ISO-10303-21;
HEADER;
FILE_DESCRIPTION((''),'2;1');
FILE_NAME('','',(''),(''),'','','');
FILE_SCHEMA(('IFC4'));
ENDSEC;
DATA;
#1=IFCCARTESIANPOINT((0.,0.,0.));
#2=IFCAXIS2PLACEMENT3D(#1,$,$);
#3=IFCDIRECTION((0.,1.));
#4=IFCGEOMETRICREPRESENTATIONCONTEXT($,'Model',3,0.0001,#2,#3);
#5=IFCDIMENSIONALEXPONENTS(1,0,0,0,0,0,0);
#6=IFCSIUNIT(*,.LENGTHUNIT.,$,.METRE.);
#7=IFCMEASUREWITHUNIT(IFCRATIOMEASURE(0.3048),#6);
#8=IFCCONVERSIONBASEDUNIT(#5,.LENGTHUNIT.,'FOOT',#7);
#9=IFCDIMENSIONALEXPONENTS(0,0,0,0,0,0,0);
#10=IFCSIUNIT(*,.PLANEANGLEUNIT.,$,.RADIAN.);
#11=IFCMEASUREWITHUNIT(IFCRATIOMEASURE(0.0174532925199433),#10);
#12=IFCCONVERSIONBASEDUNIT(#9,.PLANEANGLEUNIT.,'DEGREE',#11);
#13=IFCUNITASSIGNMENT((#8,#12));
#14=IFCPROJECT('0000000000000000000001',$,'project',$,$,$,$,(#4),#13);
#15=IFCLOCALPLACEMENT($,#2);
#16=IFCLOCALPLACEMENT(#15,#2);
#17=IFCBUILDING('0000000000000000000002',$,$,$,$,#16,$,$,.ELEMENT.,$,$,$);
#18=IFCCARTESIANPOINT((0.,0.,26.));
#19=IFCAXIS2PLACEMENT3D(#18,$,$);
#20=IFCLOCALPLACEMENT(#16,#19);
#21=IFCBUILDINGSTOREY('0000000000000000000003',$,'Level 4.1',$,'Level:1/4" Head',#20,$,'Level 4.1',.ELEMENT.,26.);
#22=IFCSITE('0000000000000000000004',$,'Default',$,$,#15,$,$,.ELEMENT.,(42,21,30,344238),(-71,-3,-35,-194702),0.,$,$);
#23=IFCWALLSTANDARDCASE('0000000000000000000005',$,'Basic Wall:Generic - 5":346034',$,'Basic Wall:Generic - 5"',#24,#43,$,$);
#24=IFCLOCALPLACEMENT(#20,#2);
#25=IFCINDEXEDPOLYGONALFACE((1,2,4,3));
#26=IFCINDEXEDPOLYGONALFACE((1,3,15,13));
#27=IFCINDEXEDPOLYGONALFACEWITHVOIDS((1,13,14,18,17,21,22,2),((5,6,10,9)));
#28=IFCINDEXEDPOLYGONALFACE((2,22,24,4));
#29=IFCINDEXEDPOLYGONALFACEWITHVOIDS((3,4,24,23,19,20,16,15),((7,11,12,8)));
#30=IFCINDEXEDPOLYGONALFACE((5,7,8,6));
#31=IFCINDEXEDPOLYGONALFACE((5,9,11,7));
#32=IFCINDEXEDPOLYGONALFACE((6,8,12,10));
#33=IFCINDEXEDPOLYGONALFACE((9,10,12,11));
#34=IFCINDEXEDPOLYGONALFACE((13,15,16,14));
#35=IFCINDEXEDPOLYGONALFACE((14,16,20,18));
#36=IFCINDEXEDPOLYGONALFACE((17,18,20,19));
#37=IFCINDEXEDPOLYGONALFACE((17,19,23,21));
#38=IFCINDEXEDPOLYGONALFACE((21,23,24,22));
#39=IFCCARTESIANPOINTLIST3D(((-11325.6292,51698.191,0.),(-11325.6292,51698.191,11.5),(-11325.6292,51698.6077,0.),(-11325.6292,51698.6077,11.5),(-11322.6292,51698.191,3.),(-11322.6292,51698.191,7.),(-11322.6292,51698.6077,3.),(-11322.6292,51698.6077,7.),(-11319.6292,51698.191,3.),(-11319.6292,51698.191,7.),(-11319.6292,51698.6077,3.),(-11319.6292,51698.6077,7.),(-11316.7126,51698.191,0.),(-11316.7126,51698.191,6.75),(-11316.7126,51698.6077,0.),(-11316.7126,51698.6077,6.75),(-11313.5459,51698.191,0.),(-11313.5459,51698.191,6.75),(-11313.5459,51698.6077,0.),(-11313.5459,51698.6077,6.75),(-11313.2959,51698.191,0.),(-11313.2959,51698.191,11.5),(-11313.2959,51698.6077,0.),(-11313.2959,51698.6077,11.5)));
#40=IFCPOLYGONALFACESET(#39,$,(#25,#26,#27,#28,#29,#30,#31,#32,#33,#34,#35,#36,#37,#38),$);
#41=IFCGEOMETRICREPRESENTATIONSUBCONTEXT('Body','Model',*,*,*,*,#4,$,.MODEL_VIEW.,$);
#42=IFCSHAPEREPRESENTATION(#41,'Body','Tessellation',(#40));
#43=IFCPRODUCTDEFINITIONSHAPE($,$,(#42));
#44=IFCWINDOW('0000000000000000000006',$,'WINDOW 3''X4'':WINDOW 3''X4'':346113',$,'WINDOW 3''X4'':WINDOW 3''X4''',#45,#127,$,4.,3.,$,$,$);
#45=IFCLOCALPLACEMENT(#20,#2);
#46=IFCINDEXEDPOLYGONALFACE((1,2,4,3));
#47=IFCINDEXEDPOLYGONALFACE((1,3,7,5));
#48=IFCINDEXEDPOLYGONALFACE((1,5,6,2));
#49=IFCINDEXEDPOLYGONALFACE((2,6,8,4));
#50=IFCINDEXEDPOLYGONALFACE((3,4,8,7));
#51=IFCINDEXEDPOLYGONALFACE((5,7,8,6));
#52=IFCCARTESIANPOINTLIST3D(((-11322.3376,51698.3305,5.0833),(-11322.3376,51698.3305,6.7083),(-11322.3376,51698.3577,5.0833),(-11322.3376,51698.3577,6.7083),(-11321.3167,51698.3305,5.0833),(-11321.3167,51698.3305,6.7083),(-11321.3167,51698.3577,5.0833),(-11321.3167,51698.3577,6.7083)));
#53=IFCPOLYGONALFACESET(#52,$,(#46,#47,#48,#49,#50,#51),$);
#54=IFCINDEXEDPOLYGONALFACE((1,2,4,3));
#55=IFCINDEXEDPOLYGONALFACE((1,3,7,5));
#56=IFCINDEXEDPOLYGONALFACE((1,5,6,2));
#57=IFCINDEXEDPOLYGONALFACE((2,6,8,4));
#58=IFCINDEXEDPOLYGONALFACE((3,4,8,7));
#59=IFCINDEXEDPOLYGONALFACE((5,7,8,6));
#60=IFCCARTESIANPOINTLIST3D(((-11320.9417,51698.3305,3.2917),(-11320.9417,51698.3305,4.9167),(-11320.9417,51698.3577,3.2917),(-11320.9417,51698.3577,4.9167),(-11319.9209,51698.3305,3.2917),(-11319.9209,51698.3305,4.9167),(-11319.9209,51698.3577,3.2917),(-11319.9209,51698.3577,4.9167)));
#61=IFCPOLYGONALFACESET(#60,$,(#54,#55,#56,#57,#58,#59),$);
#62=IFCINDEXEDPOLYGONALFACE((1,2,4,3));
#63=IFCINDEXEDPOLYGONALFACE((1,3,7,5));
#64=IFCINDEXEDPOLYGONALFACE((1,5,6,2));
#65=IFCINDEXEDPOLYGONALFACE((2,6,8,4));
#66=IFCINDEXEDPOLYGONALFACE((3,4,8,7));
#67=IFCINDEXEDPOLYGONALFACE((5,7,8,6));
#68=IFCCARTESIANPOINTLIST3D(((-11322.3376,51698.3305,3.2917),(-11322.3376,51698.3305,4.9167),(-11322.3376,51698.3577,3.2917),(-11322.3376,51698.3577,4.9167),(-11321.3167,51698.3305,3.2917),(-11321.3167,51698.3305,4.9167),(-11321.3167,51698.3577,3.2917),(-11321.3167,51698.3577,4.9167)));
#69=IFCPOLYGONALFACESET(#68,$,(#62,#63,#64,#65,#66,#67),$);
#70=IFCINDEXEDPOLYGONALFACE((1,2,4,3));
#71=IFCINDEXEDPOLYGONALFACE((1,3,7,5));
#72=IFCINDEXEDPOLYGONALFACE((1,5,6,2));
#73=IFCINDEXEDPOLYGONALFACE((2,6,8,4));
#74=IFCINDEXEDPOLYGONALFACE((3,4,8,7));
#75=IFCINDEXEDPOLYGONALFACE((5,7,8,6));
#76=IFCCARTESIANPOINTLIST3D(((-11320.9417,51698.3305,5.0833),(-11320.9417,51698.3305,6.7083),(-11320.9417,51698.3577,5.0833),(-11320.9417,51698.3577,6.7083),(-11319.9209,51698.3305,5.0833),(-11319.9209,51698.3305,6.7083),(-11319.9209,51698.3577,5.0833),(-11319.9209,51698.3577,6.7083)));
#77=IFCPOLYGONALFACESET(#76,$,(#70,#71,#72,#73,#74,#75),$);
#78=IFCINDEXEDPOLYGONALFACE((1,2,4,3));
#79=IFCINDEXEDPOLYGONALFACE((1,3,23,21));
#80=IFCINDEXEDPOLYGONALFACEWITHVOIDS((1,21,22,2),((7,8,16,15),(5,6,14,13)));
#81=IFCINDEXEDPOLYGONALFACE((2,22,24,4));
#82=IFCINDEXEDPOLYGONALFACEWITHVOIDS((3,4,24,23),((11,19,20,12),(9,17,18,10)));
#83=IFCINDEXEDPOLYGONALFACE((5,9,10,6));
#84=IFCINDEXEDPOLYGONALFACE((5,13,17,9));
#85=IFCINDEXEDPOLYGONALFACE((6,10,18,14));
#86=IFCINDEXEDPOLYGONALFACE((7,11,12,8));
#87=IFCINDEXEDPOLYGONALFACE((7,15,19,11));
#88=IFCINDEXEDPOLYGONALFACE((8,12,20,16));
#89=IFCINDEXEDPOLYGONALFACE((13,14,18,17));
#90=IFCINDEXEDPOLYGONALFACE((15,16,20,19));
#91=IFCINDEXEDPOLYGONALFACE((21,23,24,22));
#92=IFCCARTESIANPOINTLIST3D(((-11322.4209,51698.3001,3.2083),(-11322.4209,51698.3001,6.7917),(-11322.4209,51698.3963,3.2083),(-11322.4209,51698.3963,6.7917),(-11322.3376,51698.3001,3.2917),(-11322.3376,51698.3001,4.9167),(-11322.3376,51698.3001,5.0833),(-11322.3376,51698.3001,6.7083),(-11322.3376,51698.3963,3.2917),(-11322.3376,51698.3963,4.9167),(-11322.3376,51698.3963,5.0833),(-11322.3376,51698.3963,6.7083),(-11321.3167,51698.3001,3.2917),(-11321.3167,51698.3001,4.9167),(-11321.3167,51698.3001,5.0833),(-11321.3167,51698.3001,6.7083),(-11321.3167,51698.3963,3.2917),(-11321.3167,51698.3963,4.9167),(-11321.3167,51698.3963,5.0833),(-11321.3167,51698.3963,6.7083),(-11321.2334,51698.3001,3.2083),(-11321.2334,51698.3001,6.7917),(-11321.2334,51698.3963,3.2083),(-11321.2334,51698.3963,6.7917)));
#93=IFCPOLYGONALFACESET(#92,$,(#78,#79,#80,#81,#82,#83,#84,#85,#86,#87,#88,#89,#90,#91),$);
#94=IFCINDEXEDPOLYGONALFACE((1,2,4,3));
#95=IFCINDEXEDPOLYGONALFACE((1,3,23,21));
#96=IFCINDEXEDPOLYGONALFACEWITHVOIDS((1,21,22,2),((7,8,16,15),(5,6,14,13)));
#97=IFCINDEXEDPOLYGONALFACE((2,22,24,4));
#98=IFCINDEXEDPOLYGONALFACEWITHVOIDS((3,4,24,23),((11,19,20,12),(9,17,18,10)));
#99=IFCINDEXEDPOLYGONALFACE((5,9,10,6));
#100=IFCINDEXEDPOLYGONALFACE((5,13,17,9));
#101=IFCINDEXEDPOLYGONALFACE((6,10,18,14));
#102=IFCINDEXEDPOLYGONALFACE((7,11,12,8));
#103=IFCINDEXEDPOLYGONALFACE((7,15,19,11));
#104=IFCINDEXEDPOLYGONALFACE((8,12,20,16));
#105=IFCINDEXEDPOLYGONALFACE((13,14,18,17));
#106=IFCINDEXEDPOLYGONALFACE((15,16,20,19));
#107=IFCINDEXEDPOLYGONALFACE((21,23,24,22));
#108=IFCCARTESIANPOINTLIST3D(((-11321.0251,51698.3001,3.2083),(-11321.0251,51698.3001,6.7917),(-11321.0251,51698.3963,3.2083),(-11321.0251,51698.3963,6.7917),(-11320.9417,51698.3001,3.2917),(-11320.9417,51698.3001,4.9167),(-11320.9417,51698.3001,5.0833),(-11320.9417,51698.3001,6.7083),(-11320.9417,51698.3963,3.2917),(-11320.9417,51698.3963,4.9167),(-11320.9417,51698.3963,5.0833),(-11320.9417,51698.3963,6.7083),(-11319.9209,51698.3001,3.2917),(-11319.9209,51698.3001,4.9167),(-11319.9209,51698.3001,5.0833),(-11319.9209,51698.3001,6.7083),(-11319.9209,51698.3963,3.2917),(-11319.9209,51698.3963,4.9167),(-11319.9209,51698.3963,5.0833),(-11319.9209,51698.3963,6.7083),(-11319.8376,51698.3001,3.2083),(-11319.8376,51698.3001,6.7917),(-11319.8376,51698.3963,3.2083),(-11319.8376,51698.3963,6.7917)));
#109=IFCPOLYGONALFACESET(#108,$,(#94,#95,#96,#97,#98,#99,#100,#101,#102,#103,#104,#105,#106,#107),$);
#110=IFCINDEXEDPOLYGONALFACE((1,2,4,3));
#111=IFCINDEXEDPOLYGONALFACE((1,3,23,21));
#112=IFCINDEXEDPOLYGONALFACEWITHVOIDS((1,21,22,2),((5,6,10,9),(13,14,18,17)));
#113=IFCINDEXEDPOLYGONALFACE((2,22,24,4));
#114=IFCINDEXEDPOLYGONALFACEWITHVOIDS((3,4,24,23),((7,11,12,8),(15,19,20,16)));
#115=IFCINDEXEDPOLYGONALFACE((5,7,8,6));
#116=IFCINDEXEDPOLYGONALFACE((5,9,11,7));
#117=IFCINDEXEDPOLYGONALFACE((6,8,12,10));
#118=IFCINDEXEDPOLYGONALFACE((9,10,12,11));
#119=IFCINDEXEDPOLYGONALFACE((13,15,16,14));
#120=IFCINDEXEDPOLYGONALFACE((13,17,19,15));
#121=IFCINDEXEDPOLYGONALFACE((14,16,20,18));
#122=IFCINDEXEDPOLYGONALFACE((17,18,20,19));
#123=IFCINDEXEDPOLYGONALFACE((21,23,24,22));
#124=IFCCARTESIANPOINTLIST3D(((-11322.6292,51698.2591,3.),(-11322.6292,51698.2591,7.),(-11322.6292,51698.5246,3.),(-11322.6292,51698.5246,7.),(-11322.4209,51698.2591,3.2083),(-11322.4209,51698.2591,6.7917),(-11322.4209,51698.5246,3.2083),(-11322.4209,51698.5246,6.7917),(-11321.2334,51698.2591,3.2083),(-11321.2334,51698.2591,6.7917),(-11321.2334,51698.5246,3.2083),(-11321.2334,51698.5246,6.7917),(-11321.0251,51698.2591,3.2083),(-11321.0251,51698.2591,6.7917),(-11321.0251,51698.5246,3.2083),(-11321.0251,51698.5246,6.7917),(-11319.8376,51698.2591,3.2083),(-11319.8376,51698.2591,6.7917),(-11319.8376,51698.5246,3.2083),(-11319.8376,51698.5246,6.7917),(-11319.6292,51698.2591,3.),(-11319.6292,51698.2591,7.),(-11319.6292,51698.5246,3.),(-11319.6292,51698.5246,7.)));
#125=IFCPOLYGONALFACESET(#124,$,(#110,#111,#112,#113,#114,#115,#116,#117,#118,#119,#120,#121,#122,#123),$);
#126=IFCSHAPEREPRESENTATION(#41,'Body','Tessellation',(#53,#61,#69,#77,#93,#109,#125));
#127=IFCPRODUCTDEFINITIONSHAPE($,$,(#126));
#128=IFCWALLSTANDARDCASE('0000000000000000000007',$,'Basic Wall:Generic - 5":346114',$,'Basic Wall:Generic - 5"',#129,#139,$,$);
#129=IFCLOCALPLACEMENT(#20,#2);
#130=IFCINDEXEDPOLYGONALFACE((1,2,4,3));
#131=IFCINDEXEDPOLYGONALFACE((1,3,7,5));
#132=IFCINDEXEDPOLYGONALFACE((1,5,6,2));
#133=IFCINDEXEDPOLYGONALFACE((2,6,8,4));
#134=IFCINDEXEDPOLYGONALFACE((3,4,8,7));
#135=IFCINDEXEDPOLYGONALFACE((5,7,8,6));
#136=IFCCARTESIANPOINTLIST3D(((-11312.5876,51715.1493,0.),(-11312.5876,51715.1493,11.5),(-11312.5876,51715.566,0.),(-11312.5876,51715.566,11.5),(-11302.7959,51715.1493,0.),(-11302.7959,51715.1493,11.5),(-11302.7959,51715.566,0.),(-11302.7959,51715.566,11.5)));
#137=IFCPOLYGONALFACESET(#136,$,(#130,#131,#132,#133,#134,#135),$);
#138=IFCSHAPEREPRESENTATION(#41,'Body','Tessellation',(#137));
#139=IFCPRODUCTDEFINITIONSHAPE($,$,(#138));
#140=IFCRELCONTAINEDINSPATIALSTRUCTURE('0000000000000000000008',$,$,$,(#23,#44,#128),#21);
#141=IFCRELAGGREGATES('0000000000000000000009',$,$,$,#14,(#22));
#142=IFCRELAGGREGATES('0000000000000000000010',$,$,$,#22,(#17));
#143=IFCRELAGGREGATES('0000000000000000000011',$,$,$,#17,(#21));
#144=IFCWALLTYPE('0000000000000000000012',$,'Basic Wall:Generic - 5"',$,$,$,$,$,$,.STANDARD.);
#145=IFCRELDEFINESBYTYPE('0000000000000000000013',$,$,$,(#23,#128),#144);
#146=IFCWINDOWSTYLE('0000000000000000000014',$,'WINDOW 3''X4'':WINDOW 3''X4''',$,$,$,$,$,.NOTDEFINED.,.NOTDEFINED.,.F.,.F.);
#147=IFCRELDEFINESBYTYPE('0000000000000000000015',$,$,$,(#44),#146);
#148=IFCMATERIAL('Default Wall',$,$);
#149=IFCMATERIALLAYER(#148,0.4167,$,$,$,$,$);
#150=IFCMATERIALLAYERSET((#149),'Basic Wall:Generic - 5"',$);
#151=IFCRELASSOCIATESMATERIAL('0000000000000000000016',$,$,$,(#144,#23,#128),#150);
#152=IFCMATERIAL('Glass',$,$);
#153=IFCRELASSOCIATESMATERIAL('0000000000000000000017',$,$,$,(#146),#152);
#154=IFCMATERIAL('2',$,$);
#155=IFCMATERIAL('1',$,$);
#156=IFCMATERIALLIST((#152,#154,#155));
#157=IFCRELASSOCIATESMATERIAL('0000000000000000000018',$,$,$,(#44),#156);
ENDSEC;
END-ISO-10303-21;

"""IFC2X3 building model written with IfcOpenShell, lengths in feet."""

from ifc_helpers import new_model, entity, si_unit, converted_unit, direction, frame, frame_2d, origin, origin_2d_with_axis, place, context, subcontext, project, spatial, polyline, rectangle, outline, extrude, source, transform, mapped, material, material_list, layer, layer_set, layer_usage, type_object, type_shapes, element, fill, save


model = new_model("IFC2X3")

# Units and contexts
model_context = context("Model", 3, precision=0.0001, world=origin(), true_north=direction((0.0, 1.0)))
body_context = subcontext(model_context, "Body", "Model", "MODEL_VIEW")
ifc_project = project(units=[converted_unit("LENGTHUNIT", "FOOT", entity("IfcRatioMeasure", 0.3048), si_unit("LENGTHUNIT", "METRE"), dimensions=[1, 0, 0, 0, 0, 0, 0]), converted_unit("PLANEANGLEUNIT", "DEGREE", entity("IfcRatioMeasure", 0.0174532925199433), si_unit("PLANEANGLEUNIT", "RADIAN"), dimensions=[0, 0, 0, 0, 0, 0, 0])], contexts=[model_context])

# Site, building, storey
site_placement = place(None, origin())
site = spatial("IfcSite", under=ifc_project, at=site_placement, Name="Default", CompositionType="ELEMENT", RefLatitude=(42, 21, 30, 344238), RefLongitude=(-71, -3, -35, -194702), RefElevation=0.0)
building_placement = place(site_placement, origin())
building = spatial("IfcBuilding", under=site, at=building_placement, CompositionType="ELEMENT")
storey_placement = place(building_placement, frame((0.0, 0.0, 26.0)))
storey = spatial("IfcBuildingStorey", under=building, at=storey_placement, Name="Level 4.1", ObjectType="Level:1/4\" Head", LongName="Level 4.1", CompositionType="ELEMENT", Elevation=26.0)

# Shared definitions
ifc_material_1 = material(Name="Default Wall")

# Shared definitions
ifc_layer_1 = layer(ifc_material_1, 0.4167)
ifc_layer_set_1 = layer_set([ifc_layer_1], Name="Basic Wall:Generic - 5\"")
wall_type_1 = type_object("IfcWallType", Name="Basic Wall:Generic - 5\"", PredefinedType="STANDARD", material=ifc_layer_set_1)
ifc_material_2 = material(Name="Glass")
ifc_material_3 = material(Name="2")
ifc_material_4 = material(Name="1")

# Wall, openings, window
window_style_1 = type_object("IfcWindowStyle", Name="WINDOW 3'X4':WINDOW 3'X4'", ConstructionType="NOTDEFINED", OperationType="NOTDEFINED", ParameterTakesPrecedence=False, Sizeable=False, material=ifc_material_2)
shared_shape_1 = source(origin(), body_context, "Body", "SweptSolid", [
    extrude(rectangle(XDim=0.0272, YDim=1.0208, at=origin_2d_with_axis()), frame((2.1979, 0.2636, 2.0833), z_axis=(0.0, 0.0, 1.0), x_axis=(0.0, 1.0, 0.0)), (0.0, 0.0, 1.0), 1.625),
    extrude(rectangle(XDim=0.0272, YDim=1.0208, at=origin_2d_with_axis()), frame((0.8021, 0.2636, 0.2917), z_axis=(0.0, 0.0, 1.0), x_axis=(0.0, 1.0, 0.0)), (0.0, 0.0, 1.0), 1.625),
    extrude(rectangle(XDim=0.0272, YDim=1.0208, at=origin_2d_with_axis()), frame((2.1979, 0.2636, 0.2917), z_axis=(0.0, 0.0, 1.0), x_axis=(0.0, 1.0, 0.0)), (0.0, 0.0, 1.0), 1.625),
    extrude(rectangle(XDim=0.0272, YDim=1.0208, at=origin_2d_with_axis()), frame((0.8021, 0.2636, 2.0833), z_axis=(0.0, 0.0, 1.0), x_axis=(0.0, 1.0, 0.0)), (0.0, 0.0, 1.0), 1.625),
    extrude(outline(polyline([(-0.5938, -1.7917), (0.5938, -1.7917), (0.5938, 1.7917), (-0.5938, 1.7917), (-0.5938, -1.7917)]), holes=[polyline([(-0.5104, -0.0833), (0.5104, -0.0833), (0.5104, -1.7083), (-0.5104, -1.7083), (-0.5104, -0.0833)]), polyline([(-0.5104, 1.7083), (0.5104, 1.7083), (0.5104, 0.0833), (-0.5104, 0.0833), (-0.5104, 1.7083)])]), frame((2.1979, 0.2114, 2.0), z_axis=(0.0, 1.0, 0.0), x_axis=(-1.0, 0.0, 0.0)), (0.0, 0.0, 1.0), 0.0962),
    extrude(outline(polyline([(-1.7917, -0.5937), (1.7917, -0.5937), (1.7917, 0.5937), (-1.7917, 0.5937), (-1.7917, -0.5937)]), holes=[polyline([(0.0833, -0.5104), (0.0833, 0.5104), (1.7083, 0.5104), (1.7083, -0.5104), (0.0833, -0.5104)]), polyline([(-1.7083, -0.5104), (-1.7083, 0.5104), (-0.0833, 0.5104), (-0.0833, -0.5104), (-1.7083, -0.5104)])]), frame((0.8021, 0.2114, 2.0), z_axis=(0.0, 1.0, 0.0), x_axis=(0.0, 0.0, -1.0)), (0.0, 0.0, 1.0), 0.0962),
    extrude(outline(polyline([(-1.5, -2.0), (1.5, -2.0), (1.5, 2.0), (-1.5, 2.0), (-1.5, -2.0)]), holes=[polyline([(-0.1042, 1.7917), (-0.1042, -1.7917), (-1.2917, -1.7917), (-1.2917, 1.7917), (-0.1042, 1.7917)]), polyline([(0.1042, -1.7917), (0.1042, 1.7917), (1.2917, 1.7917), (1.2917, -1.7917), (0.1042, -1.7917)])]), frame((1.5, 0.0831, 2.0), z_axis=(0.0, 1.0, 0.0), x_axis=(1.0, 0.0, 0.0)), (0.0, 0.0, 1.0), 0.2655),
])
type_shapes(window_style_1, [shared_shape_1])
ifc_layer_usage_1 = layer_usage(ifc_layer_set_1, "AXIS2", "NEGATIVE", 0.2083)
wall_1_placement = place(storey_placement, frame((-11325.6292, 51698.3993, 0.0)))
wall_1 = element("IfcWallStandardCase", 1, at=wall_1_placement, inside=storey, type_object=wall_type_1, material=ifc_layer_usage_1, Name="Basic Wall:Generic - 5\":346034", ObjectType="Basic Wall:Generic - 5\"", context=body_context, shape_type="SweptSolid", body=[
    extrude(rectangle(XDim=12.3333, YDim=0.4167, at=frame_2d((6.1667, 0.0), x_axis=(-1.0, 0.0))), origin(), (0.0, 0.0, 1.0), 11.5),
])
opening_1_placement = place(wall_1_placement, frame((8.9167, -0.2083, 0.0)))
element("IfcOpeningElement", 2, at=opening_1_placement, cuts=wall_1, ObjectType="Opening", context=body_context, shape_type="SweptSolid", body=[
    extrude(rectangle(XDim=6.75, YDim=3.1667, at=frame_2d((3.375, 1.5833), x_axis=(1.0, 0.0))), frame((0.0, 0.0, 0.0), z_axis=(0.0, 1.0, 0.0), x_axis=(0.0, 0.0, 1.0)), (0.0, 0.0, 1.0), 0.4167),
])
opening_2_placement = place(wall_1_placement, frame((6.0, 0.2083, 3.0)))
opening_2 = element("IfcOpeningElement", 3, at=opening_2_placement, cuts=wall_1, ObjectType="Opening", context=body_context, shape_type="SweptSolid", body=[
    extrude(rectangle(XDim=4.0, YDim=3.0, at=frame_2d((2.0, 1.5), x_axis=(-1.0, 0.0))), frame((0.0, 0.0, 0.0), z_axis=(0.0, -1.0, 0.0), x_axis=(0.0, 0.0, 1.0)), (0.0, 0.0, 1.0), 0.4167),
])
ifc_material_list_1 = material_list([ifc_material_2, ifc_material_3, ifc_material_4])
window_1_placement = place(opening_2_placement, frame((0.0, 0.0, 0.0), z_axis=(0.0, 0.0, 1.0), x_axis=(-1.0, 0.0, 0.0)))
window_1 = element("IfcWindow", 4, at=window_1_placement, inside=storey, type_object=window_style_1, material=ifc_material_list_1, Name="WINDOW 3'X4':WINDOW 3'X4':346113", ObjectType="WINDOW 3'X4':WINDOW 3'X4'", OverallHeight=4.0, OverallWidth=3.0, context=body_context, shape_type="MappedRepresentation", body=[
    mapped(shared_shape_1, transform((0.0, 0.0, 0.0), scale=1.0)),
])
fill(opening_2, window_1)

# Wall
ifc_layer_usage_2 = layer_usage(ifc_layer_set_1, "AXIS2", "NEGATIVE", 0.2083)
wall_2_placement = place(storey_placement, frame((-11312.5876, 51715.3577, 0.0)))
element("IfcWallStandardCase", 5, at=wall_2_placement, inside=storey, type_object=wall_type_1, material=ifc_layer_usage_2, Name="Basic Wall:Generic - 5\":346114", ObjectType="Basic Wall:Generic - 5\"", context=body_context, shape_type="SweptSolid", body=[
    extrude(rectangle(XDim=9.7917, YDim=0.4167, at=frame_2d((4.8958, 0.0), x_axis=(-1.0, 0.0))), origin(), (0.0, 0.0, 1.0), 11.5),
])

save(model, "model.ifc")
